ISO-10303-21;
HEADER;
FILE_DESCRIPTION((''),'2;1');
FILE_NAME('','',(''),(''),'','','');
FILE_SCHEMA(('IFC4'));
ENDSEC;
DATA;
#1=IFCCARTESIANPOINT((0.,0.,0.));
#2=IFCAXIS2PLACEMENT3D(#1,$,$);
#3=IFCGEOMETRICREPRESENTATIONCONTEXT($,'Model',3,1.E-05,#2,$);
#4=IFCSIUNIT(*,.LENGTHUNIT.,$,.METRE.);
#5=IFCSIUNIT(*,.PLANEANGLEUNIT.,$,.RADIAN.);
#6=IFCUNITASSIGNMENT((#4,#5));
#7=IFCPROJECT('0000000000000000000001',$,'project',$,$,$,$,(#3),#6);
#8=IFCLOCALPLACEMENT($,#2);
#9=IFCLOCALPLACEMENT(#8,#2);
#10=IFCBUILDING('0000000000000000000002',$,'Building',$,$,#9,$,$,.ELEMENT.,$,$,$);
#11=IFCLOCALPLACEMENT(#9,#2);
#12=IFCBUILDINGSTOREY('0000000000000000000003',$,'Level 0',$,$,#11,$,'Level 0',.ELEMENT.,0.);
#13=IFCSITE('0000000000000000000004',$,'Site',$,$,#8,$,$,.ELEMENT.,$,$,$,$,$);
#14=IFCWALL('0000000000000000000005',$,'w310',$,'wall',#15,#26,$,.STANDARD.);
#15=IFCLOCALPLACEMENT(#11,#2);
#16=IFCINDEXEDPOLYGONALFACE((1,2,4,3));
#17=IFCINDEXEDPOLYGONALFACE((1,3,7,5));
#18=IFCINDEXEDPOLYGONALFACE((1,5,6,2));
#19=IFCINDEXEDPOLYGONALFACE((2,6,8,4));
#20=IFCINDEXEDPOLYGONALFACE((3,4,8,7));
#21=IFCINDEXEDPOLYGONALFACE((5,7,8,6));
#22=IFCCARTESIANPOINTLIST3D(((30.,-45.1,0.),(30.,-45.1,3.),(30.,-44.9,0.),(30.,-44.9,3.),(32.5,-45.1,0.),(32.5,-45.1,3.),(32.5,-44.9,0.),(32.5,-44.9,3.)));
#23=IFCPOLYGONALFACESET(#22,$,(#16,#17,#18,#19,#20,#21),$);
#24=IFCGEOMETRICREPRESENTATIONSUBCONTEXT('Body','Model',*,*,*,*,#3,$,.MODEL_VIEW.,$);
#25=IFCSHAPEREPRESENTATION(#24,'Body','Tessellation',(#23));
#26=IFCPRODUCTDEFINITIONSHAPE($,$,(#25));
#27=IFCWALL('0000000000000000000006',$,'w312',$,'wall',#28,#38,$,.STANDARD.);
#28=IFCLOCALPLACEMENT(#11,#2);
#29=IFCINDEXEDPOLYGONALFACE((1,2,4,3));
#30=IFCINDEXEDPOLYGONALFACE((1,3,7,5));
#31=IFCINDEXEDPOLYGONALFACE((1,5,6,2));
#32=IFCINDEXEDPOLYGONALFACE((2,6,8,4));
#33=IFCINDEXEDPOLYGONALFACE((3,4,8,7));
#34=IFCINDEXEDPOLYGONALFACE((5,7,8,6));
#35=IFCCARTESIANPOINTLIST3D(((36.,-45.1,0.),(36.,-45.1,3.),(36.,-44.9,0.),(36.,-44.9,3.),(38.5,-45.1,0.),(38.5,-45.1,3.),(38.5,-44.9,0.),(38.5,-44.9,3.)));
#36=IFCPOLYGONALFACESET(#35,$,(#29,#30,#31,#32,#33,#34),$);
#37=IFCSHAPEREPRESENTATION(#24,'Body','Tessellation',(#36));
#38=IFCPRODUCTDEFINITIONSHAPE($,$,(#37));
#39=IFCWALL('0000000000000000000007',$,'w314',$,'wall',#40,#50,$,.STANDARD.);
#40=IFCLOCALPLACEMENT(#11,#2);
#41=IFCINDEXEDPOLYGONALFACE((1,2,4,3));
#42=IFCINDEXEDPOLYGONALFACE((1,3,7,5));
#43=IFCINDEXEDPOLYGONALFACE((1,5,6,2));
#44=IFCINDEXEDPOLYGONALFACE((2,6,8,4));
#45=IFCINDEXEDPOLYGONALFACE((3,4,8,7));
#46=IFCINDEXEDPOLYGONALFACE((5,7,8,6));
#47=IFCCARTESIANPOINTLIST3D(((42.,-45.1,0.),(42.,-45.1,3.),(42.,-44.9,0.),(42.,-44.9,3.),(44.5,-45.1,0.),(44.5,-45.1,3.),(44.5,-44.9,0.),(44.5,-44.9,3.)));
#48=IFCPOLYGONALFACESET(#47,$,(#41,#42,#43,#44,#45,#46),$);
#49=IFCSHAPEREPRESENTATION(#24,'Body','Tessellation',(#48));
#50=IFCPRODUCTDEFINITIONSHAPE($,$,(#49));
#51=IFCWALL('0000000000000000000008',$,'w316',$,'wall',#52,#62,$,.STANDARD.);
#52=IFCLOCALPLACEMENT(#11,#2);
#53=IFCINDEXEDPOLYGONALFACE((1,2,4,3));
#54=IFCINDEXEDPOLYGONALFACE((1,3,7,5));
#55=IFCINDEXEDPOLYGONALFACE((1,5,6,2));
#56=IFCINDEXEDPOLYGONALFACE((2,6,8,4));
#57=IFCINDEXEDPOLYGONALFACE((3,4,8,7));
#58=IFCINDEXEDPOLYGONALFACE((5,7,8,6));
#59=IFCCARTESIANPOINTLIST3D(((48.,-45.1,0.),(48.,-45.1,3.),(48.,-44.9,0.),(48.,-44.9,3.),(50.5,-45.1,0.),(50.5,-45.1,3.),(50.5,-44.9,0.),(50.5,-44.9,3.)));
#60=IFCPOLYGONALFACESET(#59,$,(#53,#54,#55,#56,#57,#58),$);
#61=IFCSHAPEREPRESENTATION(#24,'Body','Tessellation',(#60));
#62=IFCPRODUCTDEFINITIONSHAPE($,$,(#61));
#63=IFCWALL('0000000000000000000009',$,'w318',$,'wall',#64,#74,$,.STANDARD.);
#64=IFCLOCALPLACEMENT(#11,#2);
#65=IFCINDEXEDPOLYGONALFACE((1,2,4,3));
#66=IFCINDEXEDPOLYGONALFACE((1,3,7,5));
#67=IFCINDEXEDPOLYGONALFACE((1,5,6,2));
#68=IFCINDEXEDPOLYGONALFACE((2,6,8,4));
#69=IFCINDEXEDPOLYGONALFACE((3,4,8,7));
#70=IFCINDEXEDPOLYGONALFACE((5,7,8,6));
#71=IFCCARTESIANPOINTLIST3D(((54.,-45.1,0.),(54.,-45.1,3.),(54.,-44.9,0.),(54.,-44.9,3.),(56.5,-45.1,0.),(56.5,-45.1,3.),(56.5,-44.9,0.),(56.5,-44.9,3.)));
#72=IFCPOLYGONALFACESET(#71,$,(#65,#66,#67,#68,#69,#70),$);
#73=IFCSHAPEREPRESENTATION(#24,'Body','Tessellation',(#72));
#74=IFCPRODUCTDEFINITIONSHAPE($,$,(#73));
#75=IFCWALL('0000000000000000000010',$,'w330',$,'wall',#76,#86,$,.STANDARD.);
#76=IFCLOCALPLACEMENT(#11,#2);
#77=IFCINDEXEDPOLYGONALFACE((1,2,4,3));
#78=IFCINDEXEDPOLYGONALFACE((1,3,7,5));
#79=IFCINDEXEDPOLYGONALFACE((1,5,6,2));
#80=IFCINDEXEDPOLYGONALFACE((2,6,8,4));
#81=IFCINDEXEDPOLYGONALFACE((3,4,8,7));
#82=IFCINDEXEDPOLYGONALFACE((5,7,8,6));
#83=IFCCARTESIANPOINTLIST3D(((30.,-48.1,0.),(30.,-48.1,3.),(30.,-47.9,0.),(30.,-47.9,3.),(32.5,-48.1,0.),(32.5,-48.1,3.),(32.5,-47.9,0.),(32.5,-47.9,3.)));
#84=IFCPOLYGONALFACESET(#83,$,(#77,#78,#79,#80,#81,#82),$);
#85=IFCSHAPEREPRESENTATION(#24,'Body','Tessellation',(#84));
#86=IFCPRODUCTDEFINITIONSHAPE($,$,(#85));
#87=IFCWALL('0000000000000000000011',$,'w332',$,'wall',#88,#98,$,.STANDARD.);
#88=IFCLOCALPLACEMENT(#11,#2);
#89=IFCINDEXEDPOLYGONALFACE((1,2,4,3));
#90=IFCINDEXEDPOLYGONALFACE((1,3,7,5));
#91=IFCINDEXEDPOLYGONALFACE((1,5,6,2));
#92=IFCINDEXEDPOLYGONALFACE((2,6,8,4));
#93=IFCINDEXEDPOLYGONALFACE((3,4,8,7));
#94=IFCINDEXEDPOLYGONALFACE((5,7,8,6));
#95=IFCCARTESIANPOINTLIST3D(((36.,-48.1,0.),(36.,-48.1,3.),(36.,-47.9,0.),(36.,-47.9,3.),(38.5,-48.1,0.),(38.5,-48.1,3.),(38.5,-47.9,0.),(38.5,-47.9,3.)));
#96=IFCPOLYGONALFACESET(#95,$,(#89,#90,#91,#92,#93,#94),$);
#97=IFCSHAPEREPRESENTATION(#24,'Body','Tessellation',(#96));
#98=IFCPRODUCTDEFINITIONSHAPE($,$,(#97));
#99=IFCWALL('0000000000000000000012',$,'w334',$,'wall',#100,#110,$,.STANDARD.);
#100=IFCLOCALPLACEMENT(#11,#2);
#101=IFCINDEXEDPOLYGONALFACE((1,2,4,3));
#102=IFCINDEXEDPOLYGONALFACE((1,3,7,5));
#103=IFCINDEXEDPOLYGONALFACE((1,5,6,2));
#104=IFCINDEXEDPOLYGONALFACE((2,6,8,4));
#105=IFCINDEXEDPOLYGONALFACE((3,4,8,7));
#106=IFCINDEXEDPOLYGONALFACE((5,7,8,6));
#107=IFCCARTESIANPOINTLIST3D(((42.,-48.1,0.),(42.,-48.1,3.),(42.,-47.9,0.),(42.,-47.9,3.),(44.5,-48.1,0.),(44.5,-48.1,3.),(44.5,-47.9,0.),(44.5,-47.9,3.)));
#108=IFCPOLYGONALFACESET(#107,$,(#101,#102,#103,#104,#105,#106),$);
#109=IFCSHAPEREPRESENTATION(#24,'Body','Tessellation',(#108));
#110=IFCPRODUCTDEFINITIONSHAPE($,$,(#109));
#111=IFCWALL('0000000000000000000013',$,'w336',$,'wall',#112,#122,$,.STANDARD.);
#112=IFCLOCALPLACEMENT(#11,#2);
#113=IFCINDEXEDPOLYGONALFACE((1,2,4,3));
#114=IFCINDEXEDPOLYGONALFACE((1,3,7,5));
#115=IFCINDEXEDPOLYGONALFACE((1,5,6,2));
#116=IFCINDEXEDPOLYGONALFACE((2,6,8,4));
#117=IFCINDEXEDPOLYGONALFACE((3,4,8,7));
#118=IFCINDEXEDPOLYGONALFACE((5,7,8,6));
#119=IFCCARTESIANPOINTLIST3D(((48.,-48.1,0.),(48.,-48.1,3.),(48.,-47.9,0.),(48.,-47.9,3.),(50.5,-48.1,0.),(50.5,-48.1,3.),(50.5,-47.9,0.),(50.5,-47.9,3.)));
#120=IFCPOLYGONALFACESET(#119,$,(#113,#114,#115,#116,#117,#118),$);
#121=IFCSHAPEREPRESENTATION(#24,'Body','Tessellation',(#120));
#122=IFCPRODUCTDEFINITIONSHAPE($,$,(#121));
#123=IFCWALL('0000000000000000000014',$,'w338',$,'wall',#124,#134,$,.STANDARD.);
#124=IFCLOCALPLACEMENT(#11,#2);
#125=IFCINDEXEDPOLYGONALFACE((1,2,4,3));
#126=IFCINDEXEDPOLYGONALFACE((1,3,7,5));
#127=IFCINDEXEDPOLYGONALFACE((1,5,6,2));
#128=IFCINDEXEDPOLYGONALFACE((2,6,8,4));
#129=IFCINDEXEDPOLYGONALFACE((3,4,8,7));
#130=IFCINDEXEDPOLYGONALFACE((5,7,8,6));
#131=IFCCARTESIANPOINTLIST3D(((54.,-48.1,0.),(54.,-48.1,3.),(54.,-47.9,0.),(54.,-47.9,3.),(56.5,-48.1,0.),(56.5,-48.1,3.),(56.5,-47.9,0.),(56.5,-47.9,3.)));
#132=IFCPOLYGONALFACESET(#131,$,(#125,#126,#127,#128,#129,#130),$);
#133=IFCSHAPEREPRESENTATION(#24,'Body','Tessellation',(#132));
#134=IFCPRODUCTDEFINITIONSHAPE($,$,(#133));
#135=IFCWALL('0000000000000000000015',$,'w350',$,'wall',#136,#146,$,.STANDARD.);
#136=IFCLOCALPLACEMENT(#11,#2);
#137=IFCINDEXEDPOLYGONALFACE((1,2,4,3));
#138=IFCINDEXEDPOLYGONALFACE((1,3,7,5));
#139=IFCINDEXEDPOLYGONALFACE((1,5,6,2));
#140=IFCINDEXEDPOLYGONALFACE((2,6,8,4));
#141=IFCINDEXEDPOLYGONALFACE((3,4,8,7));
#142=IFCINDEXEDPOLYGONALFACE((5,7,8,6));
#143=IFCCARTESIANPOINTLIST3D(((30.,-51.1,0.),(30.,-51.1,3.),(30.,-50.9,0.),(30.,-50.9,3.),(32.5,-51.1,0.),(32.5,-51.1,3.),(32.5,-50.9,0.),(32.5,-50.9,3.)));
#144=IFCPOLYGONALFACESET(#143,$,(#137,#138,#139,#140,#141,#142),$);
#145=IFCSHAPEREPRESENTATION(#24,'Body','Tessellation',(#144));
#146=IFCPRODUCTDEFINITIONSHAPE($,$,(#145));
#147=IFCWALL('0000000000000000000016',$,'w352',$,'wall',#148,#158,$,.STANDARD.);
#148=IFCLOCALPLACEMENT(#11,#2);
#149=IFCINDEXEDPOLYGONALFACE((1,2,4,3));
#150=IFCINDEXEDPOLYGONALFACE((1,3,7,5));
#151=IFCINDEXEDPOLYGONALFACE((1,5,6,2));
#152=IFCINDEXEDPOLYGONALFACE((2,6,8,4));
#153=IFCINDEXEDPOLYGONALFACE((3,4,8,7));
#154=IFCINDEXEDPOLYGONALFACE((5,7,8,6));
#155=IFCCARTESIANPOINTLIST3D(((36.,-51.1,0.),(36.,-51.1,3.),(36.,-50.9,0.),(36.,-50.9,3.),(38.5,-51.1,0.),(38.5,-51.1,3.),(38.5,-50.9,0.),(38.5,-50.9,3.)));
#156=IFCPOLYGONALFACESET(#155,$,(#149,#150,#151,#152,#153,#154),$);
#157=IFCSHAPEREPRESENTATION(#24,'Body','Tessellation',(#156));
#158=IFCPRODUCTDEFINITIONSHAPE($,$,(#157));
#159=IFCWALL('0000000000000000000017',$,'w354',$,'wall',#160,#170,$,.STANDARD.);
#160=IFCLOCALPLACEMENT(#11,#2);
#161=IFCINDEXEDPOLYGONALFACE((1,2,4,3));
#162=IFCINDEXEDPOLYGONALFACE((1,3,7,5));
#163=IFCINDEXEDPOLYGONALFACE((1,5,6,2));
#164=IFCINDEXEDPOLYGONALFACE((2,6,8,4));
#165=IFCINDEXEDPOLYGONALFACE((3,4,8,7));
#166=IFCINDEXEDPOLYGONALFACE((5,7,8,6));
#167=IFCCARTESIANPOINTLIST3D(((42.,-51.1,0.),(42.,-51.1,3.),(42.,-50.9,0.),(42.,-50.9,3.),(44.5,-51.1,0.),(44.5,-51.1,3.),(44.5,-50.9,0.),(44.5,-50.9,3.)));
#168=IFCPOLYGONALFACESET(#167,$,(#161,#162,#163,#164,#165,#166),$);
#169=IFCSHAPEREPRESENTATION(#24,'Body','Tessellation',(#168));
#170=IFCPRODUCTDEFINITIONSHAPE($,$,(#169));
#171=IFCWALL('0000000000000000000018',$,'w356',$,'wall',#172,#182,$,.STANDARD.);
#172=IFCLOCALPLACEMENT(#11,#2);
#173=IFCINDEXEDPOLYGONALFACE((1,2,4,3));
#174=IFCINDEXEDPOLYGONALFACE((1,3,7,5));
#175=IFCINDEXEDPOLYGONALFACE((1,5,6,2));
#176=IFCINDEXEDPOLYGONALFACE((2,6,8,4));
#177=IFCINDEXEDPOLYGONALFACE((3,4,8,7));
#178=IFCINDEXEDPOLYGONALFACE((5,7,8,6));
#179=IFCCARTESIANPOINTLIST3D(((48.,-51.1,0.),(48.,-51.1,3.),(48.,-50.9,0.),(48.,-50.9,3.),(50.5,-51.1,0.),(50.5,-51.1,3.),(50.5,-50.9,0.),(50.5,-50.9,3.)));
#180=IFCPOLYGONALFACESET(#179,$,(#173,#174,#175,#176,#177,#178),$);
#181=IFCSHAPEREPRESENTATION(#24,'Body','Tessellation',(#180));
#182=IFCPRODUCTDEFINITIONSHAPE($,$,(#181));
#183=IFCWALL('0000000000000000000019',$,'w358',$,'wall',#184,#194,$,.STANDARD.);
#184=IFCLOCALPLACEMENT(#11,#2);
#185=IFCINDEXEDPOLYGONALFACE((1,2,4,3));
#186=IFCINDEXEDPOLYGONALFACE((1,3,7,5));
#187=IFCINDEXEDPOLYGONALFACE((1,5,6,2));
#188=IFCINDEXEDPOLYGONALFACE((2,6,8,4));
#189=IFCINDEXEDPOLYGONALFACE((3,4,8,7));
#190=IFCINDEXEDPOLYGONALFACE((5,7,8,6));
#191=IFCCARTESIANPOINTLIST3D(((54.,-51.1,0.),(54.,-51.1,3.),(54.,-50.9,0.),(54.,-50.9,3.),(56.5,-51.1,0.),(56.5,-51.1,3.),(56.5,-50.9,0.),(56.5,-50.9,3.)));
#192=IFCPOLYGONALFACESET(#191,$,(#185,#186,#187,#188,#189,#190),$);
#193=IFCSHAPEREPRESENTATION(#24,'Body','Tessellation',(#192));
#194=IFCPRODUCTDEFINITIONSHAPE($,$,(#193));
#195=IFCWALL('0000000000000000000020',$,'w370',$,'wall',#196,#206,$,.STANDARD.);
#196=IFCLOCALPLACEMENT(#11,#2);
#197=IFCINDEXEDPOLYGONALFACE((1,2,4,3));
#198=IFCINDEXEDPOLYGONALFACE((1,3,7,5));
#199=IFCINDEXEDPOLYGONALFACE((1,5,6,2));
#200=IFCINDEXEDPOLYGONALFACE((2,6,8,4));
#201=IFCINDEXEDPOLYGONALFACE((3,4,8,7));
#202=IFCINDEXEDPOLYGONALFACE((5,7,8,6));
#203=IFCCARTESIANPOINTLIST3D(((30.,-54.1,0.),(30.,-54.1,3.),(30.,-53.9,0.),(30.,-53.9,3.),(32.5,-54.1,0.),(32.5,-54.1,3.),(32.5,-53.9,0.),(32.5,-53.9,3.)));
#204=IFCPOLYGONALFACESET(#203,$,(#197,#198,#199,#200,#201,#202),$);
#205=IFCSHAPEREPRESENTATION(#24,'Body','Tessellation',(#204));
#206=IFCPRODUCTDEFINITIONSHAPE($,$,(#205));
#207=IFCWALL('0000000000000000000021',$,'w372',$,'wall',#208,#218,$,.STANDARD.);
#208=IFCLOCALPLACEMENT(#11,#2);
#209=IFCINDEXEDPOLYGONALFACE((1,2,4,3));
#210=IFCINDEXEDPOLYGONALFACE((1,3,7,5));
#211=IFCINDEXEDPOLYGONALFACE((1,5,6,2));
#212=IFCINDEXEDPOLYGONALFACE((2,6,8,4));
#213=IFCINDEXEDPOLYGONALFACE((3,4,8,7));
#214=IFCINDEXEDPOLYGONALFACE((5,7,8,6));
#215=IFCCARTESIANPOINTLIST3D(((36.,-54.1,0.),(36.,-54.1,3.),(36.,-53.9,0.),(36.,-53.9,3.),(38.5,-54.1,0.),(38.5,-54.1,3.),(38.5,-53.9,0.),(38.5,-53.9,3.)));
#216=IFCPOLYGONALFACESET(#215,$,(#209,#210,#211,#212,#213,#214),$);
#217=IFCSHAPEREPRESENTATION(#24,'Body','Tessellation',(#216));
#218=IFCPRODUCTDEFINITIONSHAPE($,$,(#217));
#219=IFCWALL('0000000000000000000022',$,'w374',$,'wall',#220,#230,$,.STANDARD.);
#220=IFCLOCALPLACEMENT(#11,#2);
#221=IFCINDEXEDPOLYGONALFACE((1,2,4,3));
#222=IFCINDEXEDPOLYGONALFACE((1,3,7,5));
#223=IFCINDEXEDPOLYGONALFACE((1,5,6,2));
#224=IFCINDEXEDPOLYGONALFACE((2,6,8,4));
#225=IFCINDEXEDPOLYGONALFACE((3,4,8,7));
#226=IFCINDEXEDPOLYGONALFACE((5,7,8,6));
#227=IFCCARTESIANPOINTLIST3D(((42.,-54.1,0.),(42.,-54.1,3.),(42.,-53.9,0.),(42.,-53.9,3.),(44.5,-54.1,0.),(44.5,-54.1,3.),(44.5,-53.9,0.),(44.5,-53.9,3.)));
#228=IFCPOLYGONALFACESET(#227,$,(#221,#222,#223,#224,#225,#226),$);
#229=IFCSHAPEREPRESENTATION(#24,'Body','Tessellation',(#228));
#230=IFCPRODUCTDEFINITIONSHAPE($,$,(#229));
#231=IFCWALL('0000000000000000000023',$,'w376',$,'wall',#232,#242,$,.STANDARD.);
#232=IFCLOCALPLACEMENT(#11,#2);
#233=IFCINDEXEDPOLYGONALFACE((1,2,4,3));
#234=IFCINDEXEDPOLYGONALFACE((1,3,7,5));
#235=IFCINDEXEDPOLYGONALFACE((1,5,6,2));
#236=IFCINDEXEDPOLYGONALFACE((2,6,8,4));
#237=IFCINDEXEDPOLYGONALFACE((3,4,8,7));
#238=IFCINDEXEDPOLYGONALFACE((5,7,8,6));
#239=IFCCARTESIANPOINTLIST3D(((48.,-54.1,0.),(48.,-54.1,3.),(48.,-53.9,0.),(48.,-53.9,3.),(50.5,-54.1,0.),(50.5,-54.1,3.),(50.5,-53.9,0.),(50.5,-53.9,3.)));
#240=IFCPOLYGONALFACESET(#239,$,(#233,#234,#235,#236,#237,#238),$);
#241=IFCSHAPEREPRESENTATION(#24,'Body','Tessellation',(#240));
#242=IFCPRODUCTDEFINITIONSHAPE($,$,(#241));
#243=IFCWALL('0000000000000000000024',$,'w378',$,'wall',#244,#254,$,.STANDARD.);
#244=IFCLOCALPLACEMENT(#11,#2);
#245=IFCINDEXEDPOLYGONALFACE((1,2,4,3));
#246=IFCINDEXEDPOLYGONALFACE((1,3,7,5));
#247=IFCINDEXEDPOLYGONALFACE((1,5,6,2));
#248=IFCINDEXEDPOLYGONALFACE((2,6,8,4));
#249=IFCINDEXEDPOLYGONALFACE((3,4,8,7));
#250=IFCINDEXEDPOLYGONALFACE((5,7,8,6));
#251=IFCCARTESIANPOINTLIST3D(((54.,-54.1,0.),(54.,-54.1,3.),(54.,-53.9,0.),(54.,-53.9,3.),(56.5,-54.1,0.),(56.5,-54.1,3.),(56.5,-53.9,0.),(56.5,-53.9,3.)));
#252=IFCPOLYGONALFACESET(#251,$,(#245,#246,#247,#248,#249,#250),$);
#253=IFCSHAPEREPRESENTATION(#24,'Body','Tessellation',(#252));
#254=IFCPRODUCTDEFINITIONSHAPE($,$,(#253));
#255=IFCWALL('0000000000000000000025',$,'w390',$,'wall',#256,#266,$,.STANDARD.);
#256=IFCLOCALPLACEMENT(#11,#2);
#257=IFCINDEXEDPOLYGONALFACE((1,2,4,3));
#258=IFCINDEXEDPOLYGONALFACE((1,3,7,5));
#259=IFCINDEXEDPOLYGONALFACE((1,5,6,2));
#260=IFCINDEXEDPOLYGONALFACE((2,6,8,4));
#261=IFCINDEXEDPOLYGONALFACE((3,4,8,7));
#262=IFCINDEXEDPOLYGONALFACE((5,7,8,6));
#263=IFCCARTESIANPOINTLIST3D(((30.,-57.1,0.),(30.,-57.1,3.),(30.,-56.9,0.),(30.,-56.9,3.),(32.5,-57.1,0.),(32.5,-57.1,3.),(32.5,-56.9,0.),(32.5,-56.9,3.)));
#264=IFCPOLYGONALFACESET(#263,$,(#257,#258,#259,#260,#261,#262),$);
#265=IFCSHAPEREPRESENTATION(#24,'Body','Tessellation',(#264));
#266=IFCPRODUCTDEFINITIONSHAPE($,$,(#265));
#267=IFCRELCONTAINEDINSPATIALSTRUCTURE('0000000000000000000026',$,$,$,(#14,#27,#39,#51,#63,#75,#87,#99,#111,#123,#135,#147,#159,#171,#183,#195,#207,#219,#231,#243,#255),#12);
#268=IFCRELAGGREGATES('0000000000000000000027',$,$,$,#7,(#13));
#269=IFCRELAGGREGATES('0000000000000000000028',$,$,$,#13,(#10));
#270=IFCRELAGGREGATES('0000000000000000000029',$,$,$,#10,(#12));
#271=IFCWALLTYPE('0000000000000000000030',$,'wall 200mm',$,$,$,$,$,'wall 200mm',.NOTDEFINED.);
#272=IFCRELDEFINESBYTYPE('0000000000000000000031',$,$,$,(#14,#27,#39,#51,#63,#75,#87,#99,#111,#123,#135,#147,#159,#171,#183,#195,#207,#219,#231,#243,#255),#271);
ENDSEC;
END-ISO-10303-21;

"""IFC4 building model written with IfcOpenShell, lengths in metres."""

from ifc_helpers import new_model, si_unit, frame, frame_2d, origin, place, context, subcontext, project, spatial, rectangle, extrude, type_object, element, save


model = new_model("IFC4")

# Units and contexts
model_context = context("Model", 3, precision=1e-05, world=origin())
body_context = subcontext(model_context, "Body", "Model", "MODEL_VIEW")
ifc_project = project(units=[si_unit("LENGTHUNIT", "METRE"), si_unit("PLANEANGLEUNIT", "RADIAN")], contexts=[model_context])

# Site, building, storey
site_placement = place(None, origin())
site = spatial("IfcSite", under=ifc_project, at=site_placement, Name="Site", CompositionType="ELEMENT")
building_placement = place(site_placement, origin())
building = spatial("IfcBuilding", under=site, at=building_placement, Name="Building", CompositionType="ELEMENT")
storey_placement = place(building_placement, origin())
storey = spatial("IfcBuildingStorey", under=building, at=storey_placement, Name="Level 0", LongName="Level 0", CompositionType="ELEMENT", Elevation=0.0)

# Walls
wall_type = type_object("IfcWallType", Name="wall 200mm", ElementType="wall 200mm", PredefinedType="NOTDEFINED")
for number, where, z_axis, x_axis, name in (
    (1, (30.0, -45.0, 0.0), (0.0, 0.0, 1.0), (1.0, 0.0, 0.0), "w310"),
    (2, (36.0, -45.0, 0.0), (0.0, 0.0, 1.0), (1.0, 0.0, 0.0), "w312"),
    (3, (42.0, -45.0, 0.0), (0.0, 0.0, 1.0), (1.0, 0.0, 0.0), "w314"),
    (4, (48.0, -45.0, 0.0), (0.0, 0.0, 1.0), (1.0, 0.0, 0.0), "w316"),
    (5, (54.0, -45.0, 0.0), (0.0, 0.0, 1.0), (1.0, 0.0, 0.0), "w318"),
    (6, (30.0, -48.0, 0.0), (0.0, 0.0, 1.0), (1.0, 0.0, 0.0), "w330"),
    (7, (36.0, -48.0, 0.0), (0.0, 0.0, 1.0), (1.0, 0.0, 0.0), "w332"),
    (8, (42.0, -48.0, 0.0), (0.0, 0.0, 1.0), (1.0, 0.0, 0.0), "w334"),
    (9, (48.0, -48.0, 0.0), (0.0, 0.0, 1.0), (1.0, 0.0, 0.0), "w336"),
    (10, (54.0, -48.0, 0.0), (0.0, 0.0, 1.0), (1.0, 0.0, 0.0), "w338"),
    (11, (30.0, -51.0, 0.0), (0.0, 0.0, 1.0), (1.0, 0.0, 0.0), "w350"),
    (12, (36.0, -51.0, 0.0), (0.0, 0.0, 1.0), (1.0, 0.0, 0.0), "w352"),
    (13, (42.0, -51.0, 0.0), (0.0, 0.0, 1.0), (1.0, 0.0, 0.0), "w354"),
    (14, (48.0, -51.0, 0.0), (0.0, 0.0, 1.0), (1.0, 0.0, 0.0), "w356"),
    (15, (54.0, -51.0, 0.0), (0.0, 0.0, 1.0), (1.0, 0.0, 0.0), "w358"),
    (16, (30.0, -54.0, 0.0), (0.0, 0.0, 1.0), (1.0, 0.0, 0.0), "w370"),
    (17, (36.0, -54.0, 0.0), (0.0, 0.0, 1.0), (1.0, 0.0, 0.0), "w372"),
    (18, (42.0, -54.0, 0.0), (0.0, 0.0, 1.0), (1.0, 0.0, 0.0), "w374"),
    (19, (48.0, -54.0, 0.0), (0.0, 0.0, 1.0), (1.0, 0.0, 0.0), "w376"),
    (20, (54.0, -54.0, 0.0), (0.0, 0.0, 1.0), (1.0, 0.0, 0.0), "w378"),
    (21, (30.0, -57.0, 0.0), (0.0, 0.0, 1.0), (1.0, 0.0, 0.0), "w390"),
):
    element("IfcWall", number, at=place(storey_placement, frame(where, z_axis=z_axis, x_axis=x_axis)), inside=storey, type_object=wall_type, Name=name, ObjectType="wall", PredefinedType="STANDARD", context=body_context, shape_type="SweptSolid", body=[
        extrude(rectangle(XDim=2.5, YDim=0.2, at=frame_2d((1.25, 0.0))), origin(), (0.0, 0.0, 1.0), 3.0),
    ])

save(model, "model.ifc")
